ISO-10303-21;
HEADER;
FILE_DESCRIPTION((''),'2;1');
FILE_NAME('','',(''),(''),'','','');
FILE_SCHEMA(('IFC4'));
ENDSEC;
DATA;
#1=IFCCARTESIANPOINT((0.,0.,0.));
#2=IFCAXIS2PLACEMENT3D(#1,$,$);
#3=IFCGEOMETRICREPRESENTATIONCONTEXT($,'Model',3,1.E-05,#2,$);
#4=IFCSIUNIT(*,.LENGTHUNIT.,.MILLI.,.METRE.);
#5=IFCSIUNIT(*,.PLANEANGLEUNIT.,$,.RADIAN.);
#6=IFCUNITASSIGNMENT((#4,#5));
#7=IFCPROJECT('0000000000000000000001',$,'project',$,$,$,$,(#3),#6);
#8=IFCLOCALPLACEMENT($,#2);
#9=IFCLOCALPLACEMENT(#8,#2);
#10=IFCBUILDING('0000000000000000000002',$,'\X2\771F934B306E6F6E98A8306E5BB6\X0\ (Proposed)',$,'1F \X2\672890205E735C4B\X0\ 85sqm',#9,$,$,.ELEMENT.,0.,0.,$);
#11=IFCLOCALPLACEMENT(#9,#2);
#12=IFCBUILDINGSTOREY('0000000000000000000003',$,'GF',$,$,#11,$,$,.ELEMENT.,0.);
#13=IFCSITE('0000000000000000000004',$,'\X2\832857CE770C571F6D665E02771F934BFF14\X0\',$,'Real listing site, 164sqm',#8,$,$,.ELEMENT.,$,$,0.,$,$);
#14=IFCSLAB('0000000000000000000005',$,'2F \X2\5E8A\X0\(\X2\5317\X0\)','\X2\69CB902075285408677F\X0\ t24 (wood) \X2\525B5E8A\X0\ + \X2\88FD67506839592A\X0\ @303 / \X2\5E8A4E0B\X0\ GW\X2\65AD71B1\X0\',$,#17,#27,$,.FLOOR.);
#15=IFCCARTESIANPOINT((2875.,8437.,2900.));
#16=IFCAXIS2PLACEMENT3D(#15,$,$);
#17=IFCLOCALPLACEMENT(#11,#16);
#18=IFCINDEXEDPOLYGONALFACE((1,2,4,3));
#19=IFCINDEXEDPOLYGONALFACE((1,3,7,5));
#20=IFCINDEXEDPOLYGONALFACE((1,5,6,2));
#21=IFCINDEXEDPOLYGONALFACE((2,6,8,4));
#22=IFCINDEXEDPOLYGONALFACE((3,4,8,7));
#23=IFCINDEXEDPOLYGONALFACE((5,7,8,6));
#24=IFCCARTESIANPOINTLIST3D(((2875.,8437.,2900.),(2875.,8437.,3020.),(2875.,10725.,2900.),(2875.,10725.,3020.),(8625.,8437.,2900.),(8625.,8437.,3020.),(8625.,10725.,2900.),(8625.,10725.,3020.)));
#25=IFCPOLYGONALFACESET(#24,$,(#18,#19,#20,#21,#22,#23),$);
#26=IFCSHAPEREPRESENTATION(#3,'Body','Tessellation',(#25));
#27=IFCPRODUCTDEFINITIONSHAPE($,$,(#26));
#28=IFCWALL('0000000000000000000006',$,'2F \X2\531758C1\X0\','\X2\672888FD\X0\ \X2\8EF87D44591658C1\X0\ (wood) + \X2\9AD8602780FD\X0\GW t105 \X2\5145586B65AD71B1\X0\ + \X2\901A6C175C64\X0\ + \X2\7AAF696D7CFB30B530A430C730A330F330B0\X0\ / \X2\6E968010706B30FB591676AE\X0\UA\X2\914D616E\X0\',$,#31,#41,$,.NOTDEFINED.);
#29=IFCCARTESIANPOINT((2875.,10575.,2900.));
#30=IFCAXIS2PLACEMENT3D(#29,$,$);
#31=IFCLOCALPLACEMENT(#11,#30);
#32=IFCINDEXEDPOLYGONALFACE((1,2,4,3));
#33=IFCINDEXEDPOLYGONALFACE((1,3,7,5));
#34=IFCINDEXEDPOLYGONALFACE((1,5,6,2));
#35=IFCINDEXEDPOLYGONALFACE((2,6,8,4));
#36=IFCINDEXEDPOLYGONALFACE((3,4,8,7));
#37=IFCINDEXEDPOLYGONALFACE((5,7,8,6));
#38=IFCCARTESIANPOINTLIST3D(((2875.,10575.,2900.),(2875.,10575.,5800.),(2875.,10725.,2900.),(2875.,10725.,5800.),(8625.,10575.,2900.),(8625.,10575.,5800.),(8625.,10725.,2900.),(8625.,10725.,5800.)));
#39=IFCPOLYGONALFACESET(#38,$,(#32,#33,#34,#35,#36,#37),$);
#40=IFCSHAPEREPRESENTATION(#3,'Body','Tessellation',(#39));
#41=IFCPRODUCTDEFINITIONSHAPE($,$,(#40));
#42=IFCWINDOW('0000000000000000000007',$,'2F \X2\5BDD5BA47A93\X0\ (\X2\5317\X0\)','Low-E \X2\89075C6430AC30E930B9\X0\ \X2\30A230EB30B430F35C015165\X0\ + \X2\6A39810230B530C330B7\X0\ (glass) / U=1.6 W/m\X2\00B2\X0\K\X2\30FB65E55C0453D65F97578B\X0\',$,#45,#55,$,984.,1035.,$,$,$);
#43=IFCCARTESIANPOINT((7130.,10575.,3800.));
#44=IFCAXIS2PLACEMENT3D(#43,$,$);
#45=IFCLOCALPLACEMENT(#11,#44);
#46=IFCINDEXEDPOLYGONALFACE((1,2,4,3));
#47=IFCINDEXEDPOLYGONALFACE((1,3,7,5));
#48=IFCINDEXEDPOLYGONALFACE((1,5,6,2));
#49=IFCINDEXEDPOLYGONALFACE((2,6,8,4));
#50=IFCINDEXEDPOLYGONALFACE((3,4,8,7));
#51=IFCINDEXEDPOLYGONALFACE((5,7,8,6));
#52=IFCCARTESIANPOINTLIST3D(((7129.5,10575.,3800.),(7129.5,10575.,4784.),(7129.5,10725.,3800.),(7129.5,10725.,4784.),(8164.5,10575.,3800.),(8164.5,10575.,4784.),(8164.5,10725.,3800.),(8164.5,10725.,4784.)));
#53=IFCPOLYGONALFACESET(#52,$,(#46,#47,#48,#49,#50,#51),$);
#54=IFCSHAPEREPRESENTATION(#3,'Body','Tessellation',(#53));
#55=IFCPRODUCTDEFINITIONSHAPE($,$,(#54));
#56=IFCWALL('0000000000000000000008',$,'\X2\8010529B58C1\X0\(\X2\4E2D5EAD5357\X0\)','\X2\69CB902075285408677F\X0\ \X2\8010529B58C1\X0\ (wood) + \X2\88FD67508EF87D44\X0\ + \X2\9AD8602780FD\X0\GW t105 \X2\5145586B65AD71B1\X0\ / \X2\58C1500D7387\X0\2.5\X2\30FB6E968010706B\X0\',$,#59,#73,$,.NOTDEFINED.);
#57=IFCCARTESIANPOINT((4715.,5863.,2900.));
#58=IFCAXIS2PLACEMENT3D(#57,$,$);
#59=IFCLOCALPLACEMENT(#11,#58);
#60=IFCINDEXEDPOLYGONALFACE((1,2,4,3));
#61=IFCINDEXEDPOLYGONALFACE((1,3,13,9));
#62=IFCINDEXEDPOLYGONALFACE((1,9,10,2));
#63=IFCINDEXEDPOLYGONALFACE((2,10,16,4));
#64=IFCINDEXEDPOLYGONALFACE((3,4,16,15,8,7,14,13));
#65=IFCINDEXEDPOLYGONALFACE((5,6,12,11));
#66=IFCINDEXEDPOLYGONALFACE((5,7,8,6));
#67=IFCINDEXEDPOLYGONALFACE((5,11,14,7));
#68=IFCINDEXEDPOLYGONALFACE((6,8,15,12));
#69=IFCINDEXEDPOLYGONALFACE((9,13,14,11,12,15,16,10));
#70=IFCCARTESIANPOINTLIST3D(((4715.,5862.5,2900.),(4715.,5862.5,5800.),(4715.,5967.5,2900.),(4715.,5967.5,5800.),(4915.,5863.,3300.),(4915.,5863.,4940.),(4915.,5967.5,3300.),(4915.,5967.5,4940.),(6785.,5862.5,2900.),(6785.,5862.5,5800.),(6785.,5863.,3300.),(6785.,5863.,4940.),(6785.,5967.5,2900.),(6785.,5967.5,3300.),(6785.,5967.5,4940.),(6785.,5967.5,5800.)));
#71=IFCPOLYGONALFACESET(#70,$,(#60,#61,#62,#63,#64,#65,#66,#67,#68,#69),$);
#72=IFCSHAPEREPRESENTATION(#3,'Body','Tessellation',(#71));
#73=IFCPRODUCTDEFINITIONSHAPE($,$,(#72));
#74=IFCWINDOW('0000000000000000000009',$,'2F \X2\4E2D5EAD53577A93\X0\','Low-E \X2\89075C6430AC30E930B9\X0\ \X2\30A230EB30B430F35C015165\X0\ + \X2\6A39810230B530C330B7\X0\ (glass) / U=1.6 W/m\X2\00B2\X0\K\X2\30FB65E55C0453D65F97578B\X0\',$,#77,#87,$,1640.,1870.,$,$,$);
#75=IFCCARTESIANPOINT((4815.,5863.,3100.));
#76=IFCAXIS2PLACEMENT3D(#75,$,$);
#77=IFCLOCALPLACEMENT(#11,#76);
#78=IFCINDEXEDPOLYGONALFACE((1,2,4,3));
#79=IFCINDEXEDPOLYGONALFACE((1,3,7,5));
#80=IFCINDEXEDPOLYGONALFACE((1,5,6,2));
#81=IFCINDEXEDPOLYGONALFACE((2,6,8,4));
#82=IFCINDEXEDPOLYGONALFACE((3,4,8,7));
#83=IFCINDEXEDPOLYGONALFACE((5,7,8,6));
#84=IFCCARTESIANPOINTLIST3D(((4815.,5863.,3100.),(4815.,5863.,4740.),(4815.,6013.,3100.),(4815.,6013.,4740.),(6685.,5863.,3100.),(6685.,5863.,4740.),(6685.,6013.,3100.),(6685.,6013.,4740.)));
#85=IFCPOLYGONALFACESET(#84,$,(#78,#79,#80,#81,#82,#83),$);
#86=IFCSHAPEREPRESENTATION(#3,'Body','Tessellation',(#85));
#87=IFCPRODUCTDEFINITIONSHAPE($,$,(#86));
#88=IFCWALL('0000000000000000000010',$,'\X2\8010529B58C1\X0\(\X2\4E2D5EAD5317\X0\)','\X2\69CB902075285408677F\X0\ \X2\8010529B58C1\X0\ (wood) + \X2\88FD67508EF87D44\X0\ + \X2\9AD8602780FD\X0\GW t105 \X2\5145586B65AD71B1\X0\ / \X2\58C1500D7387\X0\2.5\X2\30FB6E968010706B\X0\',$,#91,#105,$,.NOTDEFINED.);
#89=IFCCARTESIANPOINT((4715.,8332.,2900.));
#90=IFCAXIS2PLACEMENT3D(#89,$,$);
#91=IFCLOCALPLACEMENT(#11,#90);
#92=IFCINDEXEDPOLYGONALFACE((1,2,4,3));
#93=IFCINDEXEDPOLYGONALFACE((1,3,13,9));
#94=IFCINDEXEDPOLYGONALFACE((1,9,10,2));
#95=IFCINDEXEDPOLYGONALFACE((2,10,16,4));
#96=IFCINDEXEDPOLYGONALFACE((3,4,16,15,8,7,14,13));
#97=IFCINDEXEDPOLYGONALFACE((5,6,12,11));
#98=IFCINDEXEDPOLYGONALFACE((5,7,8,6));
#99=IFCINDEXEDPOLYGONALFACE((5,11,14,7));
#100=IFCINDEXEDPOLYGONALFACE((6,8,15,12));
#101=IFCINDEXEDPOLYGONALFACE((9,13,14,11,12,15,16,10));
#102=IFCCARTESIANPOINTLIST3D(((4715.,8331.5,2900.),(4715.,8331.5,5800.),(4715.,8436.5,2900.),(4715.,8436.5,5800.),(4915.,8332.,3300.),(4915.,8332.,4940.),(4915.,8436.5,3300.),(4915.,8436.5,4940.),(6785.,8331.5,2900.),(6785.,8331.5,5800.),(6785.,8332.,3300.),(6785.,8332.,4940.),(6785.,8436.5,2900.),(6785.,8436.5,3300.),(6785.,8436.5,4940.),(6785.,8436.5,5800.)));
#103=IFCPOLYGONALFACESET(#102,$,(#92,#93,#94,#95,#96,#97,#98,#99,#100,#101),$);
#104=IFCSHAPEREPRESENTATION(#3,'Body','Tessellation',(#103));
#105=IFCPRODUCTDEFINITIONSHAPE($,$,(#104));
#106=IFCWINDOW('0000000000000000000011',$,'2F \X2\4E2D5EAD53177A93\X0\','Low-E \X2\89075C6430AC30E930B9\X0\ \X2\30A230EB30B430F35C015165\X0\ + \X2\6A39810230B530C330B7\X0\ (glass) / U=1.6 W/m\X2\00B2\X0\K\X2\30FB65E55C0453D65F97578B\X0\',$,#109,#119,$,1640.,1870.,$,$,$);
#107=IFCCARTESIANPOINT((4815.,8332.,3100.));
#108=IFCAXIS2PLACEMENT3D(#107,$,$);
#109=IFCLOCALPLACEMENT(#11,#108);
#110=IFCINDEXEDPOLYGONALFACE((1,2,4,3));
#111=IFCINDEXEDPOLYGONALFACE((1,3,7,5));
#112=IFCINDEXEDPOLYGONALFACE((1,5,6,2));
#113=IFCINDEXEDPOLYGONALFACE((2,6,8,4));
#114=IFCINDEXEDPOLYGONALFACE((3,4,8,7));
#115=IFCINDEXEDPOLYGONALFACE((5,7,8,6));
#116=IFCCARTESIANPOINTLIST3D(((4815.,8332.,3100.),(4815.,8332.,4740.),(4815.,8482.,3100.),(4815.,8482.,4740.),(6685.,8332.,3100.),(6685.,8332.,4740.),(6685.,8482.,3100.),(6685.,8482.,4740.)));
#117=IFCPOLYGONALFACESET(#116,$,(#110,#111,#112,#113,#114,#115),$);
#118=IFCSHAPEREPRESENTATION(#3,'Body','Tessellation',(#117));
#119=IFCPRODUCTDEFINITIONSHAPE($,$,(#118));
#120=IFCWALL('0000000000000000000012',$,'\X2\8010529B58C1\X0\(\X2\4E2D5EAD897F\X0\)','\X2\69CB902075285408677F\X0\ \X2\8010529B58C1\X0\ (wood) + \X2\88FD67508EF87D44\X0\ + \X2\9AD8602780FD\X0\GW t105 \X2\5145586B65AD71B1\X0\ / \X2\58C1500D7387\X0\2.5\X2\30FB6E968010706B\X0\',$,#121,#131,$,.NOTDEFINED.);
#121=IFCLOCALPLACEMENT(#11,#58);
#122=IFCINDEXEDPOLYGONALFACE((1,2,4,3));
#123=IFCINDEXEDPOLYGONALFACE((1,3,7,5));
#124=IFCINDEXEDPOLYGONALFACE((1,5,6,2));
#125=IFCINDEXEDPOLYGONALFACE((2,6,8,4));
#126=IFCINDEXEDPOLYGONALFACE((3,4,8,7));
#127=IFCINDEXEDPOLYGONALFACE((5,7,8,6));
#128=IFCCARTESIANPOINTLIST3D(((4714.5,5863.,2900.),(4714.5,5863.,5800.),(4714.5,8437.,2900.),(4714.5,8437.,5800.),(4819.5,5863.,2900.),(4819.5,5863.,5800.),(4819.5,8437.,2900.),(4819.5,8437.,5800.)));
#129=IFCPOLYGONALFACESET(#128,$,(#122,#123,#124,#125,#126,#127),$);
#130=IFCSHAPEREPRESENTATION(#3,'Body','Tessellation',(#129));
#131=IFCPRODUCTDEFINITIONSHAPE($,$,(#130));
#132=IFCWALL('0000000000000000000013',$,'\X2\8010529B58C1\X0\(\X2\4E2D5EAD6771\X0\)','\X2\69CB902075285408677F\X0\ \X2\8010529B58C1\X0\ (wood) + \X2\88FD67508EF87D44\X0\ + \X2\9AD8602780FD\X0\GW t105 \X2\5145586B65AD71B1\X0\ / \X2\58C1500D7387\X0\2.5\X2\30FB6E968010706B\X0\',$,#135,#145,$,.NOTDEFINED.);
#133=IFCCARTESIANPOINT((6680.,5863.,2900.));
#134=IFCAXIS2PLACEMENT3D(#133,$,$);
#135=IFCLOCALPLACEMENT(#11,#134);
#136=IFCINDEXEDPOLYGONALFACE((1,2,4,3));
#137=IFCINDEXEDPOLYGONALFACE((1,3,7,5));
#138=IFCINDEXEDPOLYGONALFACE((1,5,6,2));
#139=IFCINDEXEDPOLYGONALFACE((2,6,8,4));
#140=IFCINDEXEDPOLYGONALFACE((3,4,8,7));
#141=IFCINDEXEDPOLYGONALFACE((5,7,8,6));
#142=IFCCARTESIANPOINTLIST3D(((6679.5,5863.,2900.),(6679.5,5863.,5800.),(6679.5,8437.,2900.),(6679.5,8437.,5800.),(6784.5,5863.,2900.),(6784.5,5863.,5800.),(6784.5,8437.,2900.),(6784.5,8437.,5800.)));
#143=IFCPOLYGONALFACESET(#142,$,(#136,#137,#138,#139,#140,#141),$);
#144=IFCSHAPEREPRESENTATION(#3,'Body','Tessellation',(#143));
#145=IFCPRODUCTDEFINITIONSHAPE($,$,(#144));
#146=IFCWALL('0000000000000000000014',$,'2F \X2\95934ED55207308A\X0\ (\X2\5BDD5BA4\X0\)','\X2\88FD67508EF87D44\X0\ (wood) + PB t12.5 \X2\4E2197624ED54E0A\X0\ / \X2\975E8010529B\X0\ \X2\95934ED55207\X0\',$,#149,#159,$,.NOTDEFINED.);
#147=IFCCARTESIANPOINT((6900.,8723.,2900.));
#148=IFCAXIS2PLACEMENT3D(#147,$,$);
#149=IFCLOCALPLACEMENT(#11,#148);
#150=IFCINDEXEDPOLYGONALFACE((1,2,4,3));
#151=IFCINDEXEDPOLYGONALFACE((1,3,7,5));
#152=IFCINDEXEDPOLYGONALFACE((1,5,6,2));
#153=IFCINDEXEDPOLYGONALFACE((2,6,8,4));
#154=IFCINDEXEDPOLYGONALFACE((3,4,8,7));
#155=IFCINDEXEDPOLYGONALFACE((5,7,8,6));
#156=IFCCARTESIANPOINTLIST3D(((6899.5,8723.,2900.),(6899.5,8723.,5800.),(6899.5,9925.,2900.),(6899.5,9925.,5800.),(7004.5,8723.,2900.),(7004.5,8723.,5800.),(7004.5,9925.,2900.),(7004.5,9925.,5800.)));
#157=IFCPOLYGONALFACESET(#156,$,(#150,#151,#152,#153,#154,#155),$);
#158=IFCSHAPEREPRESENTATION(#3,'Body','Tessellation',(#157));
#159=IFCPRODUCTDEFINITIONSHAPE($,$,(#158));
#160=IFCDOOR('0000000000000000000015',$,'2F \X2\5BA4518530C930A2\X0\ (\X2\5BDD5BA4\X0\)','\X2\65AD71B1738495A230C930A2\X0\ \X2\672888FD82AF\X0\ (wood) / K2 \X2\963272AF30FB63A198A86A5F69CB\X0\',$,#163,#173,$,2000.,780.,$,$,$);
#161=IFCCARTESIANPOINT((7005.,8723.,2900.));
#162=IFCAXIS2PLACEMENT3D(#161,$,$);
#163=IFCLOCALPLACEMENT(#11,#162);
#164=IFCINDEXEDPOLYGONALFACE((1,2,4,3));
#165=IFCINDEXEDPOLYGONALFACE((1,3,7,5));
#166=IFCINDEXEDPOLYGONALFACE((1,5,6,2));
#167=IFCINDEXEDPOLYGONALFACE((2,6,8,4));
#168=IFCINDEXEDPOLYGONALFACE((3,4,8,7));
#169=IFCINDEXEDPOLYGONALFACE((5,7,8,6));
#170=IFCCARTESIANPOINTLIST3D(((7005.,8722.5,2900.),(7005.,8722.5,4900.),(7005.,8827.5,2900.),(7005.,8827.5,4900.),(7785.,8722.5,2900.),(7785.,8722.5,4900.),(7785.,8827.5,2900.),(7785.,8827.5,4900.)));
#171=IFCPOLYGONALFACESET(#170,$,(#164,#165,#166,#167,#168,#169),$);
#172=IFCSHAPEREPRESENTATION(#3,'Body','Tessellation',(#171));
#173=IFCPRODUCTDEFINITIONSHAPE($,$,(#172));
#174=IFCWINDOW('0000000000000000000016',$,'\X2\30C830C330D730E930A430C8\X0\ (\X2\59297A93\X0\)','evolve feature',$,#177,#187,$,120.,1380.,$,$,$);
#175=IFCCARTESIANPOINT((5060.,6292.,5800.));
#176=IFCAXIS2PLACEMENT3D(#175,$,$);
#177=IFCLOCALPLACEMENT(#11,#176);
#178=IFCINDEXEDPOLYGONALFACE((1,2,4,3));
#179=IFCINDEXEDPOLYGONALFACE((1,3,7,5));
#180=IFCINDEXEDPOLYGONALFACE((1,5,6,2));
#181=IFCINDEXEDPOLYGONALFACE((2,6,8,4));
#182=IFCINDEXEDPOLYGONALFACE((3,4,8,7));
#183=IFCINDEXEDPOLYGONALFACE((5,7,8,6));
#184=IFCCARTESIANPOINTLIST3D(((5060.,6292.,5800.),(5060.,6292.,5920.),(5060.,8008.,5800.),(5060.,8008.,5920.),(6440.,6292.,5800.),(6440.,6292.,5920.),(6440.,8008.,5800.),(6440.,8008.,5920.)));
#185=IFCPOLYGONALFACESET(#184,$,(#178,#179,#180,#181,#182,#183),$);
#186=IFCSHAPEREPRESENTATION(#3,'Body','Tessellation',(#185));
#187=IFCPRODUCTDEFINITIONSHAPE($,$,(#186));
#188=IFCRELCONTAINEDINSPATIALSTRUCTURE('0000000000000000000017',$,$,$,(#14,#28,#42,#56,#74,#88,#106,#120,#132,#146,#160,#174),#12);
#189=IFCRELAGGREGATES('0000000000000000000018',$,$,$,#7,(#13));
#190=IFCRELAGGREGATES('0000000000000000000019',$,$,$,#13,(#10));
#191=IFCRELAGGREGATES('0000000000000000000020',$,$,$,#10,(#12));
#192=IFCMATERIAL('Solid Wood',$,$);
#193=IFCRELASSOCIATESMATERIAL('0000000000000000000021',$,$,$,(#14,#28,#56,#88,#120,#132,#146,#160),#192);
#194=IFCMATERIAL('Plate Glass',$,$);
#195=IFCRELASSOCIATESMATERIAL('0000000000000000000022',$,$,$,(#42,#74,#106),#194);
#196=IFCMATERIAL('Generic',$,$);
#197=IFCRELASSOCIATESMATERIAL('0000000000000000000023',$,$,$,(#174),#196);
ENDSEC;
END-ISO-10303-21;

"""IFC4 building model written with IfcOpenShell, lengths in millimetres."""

from ifc_helpers import new_model, si_unit, frame, frame_2d, origin, place, context, project, spatial, rectangle, extrude, material, element, fill, save


model = new_model("IFC4")

# Units and contexts
model_context = context("Model", 3, precision=1e-05, world=origin())
ifc_project = project(units=[si_unit("LENGTHUNIT", "METRE", prefix="MILLI"), si_unit("PLANEANGLEUNIT", "RADIAN")], contexts=[model_context])

# Site, building, storey
site_placement = place(None, origin())
site = spatial("IfcSite", under=ifc_project, at=site_placement, Name="茨城県土浦市真鍋４", ObjectType="Real listing site, 164sqm", CompositionType="ELEMENT", RefElevation=0.0)
building_placement = place(site_placement, origin())
building = spatial("IfcBuilding", under=site, at=building_placement, Name="真鍋の潮風の家 (Proposed)", ObjectType="1F 木造平屋 85sqm", CompositionType="ELEMENT", ElevationOfRefHeight=0.0, ElevationOfTerrain=0.0)
storey_placement = place(building_placement, origin())
storey = spatial("IfcBuildingStorey", under=building, at=storey_placement, Name="GF", CompositionType="ELEMENT", Elevation=0.0)

# Slab
ifc_material_1 = material(Name="Solid Wood")
slab_placement = place(storey_placement, frame((2875.0, 8437.0, 2900.0)))
element("IfcSlab", 1, at=slab_placement, inside=storey, material=ifc_material_1, Name="2F 床(北)", Description="構造用合板 t24 (wood) 剛床 + 製材根太 @303 / 床下 GW断熱", PredefinedType="FLOOR", context=model_context, shape_type="SweptSolid", body=[
    extrude(rectangle(XDim=5750.0, YDim=2288.0, at=frame_2d((2875.0, 1144.0))), frame((2875.0, 8437.0, 2900.0)), (0.0, 0.0, 1.0), 120.0),
])

# Walls, openings, windows
wall_1_placement = place(storey_placement, frame((2875.0, 10575.0, 2900.0)))
wall_1 = element("IfcWall", 2, at=wall_1_placement, inside=storey, material=ifc_material_1, Name="2F 北壁", Description="木製 軸組外壁 (wood) + 高性能GW t105 充填断熱 + 通気層 + 窯業系サイディング / 準耐火・外皮UA配慮", PredefinedType="NOTDEFINED", context=model_context, shape_type="SweptSolid", body=[
    extrude(rectangle(XDim=5750.0, YDim=150.0, at=frame_2d((2875.0, 75.0))), frame((2875.0, 10575.0, 2900.0)), (0.0, 0.0, 1.0), 2900.0),
])
opening_1_placement = place(storey_placement, frame((7130.0, 10575.0, 3800.0)))
opening_1 = element("IfcOpeningElement", 3, at=opening_1_placement, cuts=wall_1, PredefinedType="NOTDEFINED", context=model_context, shape_type="SweptSolid", body=[
    extrude(rectangle(XDim=1035.0, YDim=150.0, at=frame_2d((517.0, 75.0))), frame((7130.0, 10575.0, 3800.0)), (0.0, 0.0, 1.0), 984.0),
])
ifc_material_2 = material(Name="Plate Glass")
window_1_placement = place(storey_placement, frame((7130.0, 10575.0, 3800.0)))
window_1 = element("IfcWindow", 4, at=window_1_placement, inside=storey, material=ifc_material_2, Name="2F 寝室窓 (北)", Description="Low-E 複層ガラス アルゴン封入 + 樹脂サッシ (glass) / U=1.6 W/m²K・日射取得型", OverallHeight=984.0, OverallWidth=1035.0, context=model_context, shape_type="SweptSolid", body=[
    extrude(rectangle(XDim=1035.0, YDim=150.0, at=frame_2d((517.0, 75.0))), frame((7130.0, 10575.0, 3800.0)), (0.0, 0.0, 1.0), 984.0),
])
fill(opening_1, window_1)
wall_2_placement = place(storey_placement, frame((4715.0, 5863.0, 2900.0)))
wall_2 = element("IfcWall", 5, at=wall_2_placement, inside=storey, material=ifc_material_1, Name="耐力壁(中庭南)", Description="構造用合板 耐力壁 (wood) + 製材軸組 + 高性能GW t105 充填断熱 / 壁倍率2.5・準耐火", PredefinedType="NOTDEFINED", context=model_context, shape_type="SweptSolid", body=[
    extrude(rectangle(XDim=2070.0, YDim=105.0, at=frame_2d((1035.0, 52.0))), frame((4715.0, 5863.0, 2900.0)), (0.0, 0.0, 1.0), 2900.0),
])
opening_2_placement = place(storey_placement, frame((4815.0, 5863.0, 3100.0)))
opening_2 = element("IfcOpeningElement", 6, at=opening_2_placement, cuts=wall_2, PredefinedType="NOTDEFINED", context=model_context, shape_type="SweptSolid", body=[
    extrude(rectangle(XDim=1870.0, YDim=150.0, at=frame_2d((935.0, 75.0))), frame((4815.0, 5863.0, 3100.0)), (0.0, 0.0, 1.0), 1640.0),
])
window_2_placement = place(storey_placement, frame((4815.0, 5863.0, 3100.0)))
window_2 = element("IfcWindow", 7, at=window_2_placement, inside=storey, material=ifc_material_2, Name="2F 中庭南窓", Description="Low-E 複層ガラス アルゴン封入 + 樹脂サッシ (glass) / U=1.6 W/m²K・日射取得型", OverallHeight=1640.0, OverallWidth=1870.0, context=model_context, shape_type="SweptSolid", body=[
    extrude(rectangle(XDim=1870.0, YDim=150.0, at=frame_2d((935.0, 75.0))), frame((4815.0, 5863.0, 3100.0)), (0.0, 0.0, 1.0), 1640.0),
])
fill(opening_2, window_2)
wall_3_placement = place(storey_placement, frame((4715.0, 8332.0, 2900.0)))
wall_3 = element("IfcWall", 8, at=wall_3_placement, inside=storey, material=ifc_material_1, Name="耐力壁(中庭北)", Description="構造用合板 耐力壁 (wood) + 製材軸組 + 高性能GW t105 充填断熱 / 壁倍率2.5・準耐火", PredefinedType="NOTDEFINED", context=model_context, shape_type="SweptSolid", body=[
    extrude(rectangle(XDim=2070.0, YDim=105.0, at=frame_2d((1035.0, 52.0))), frame((4715.0, 8332.0, 2900.0)), (0.0, 0.0, 1.0), 2900.0),
])
opening_3_placement = place(storey_placement, frame((4815.0, 8332.0, 3100.0)))
opening_3 = element("IfcOpeningElement", 9, at=opening_3_placement, cuts=wall_3, PredefinedType="NOTDEFINED", context=model_context, shape_type="SweptSolid", body=[
    extrude(rectangle(XDim=1870.0, YDim=150.0, at=frame_2d((935.0, 75.0))), frame((4815.0, 8332.0, 3100.0)), (0.0, 0.0, 1.0), 1640.0),
])
window_3_placement = place(storey_placement, frame((4815.0, 8332.0, 3100.0)))
window_3 = element("IfcWindow", 10, at=window_3_placement, inside=storey, material=ifc_material_2, Name="2F 中庭北窓", Description="Low-E 複層ガラス アルゴン封入 + 樹脂サッシ (glass) / U=1.6 W/m²K・日射取得型", OverallHeight=1640.0, OverallWidth=1870.0, context=model_context, shape_type="SweptSolid", body=[
    extrude(rectangle(XDim=1870.0, YDim=150.0, at=frame_2d((935.0, 75.0))), frame((4815.0, 8332.0, 3100.0)), (0.0, 0.0, 1.0), 1640.0),
])
fill(opening_3, window_3)

# Walls
wall_4_placement = place(storey_placement, frame((4715.0, 5863.0, 2900.0)))
element("IfcWall", 11, at=wall_4_placement, inside=storey, material=ifc_material_1, Name="耐力壁(中庭西)", Description="構造用合板 耐力壁 (wood) + 製材軸組 + 高性能GW t105 充填断熱 / 壁倍率2.5・準耐火", PredefinedType="NOTDEFINED", context=model_context, shape_type="SweptSolid", body=[
    extrude(rectangle(XDim=105.0, YDim=2574.0, at=frame_2d((52.0, 1287.0))), frame((4715.0, 5863.0, 2900.0)), (0.0, 0.0, 1.0), 2900.0),
])
wall_5_placement = place(storey_placement, frame((6680.0, 5863.0, 2900.0)))
element("IfcWall", 12, at=wall_5_placement, inside=storey, material=ifc_material_1, Name="耐力壁(中庭東)", Description="構造用合板 耐力壁 (wood) + 製材軸組 + 高性能GW t105 充填断熱 / 壁倍率2.5・準耐火", PredefinedType="NOTDEFINED", context=model_context, shape_type="SweptSolid", body=[
    extrude(rectangle(XDim=105.0, YDim=2574.0, at=frame_2d((52.0, 1287.0))), frame((6680.0, 5863.0, 2900.0)), (0.0, 0.0, 1.0), 2900.0),
])
wall_6_placement = place(storey_placement, frame((6900.0, 8723.0, 2900.0)))
element("IfcWall", 13, at=wall_6_placement, inside=storey, material=ifc_material_1, Name="2F 間仕切り (寝室)", Description="製材軸組 (wood) + PB t12.5 両面仕上 / 非耐力 間仕切", PredefinedType="NOTDEFINED", context=model_context, shape_type="SweptSolid", body=[
    extrude(rectangle(XDim=105.0, YDim=1202.0, at=frame_2d((52.0, 601.0))), frame((6900.0, 8723.0, 2900.0)), (0.0, 0.0, 1.0), 2900.0),
])

# Door
door_placement = place(storey_placement, frame((7005.0, 8723.0, 2900.0)))
element("IfcDoor", 14, at=door_placement, inside=storey, material=ifc_material_1, Name="2F 室内ドア (寝室)", Description="断熱玄関ドア 木製芯 (wood) / K2 防犯・採風機構", OverallHeight=2000.0, OverallWidth=780.0, context=model_context, shape_type="SweptSolid", body=[
    extrude(rectangle(XDim=780.0, YDim=105.0, at=frame_2d((390.0, 52.0))), frame((7005.0, 8723.0, 2900.0)), (0.0, 0.0, 1.0), 2000.0),
])

# Window
ifc_material_3 = material(Name="Generic")
window_4_placement = place(storey_placement, frame((5060.0, 6292.0, 5800.0)))
element("IfcWindow", 15, at=window_4_placement, inside=storey, material=ifc_material_3, Name="トップライト (天窓)", Description="evolve feature", OverallHeight=120.0, OverallWidth=1380.0, context=model_context, shape_type="SweptSolid", body=[
    extrude(rectangle(XDim=1380.0, YDim=1716.0, at=frame_2d((690.0, 858.0))), frame((5060.0, 6292.0, 5800.0)), (0.0, 0.0, 1.0), 120.0),
])

save(model, "model.ifc")
